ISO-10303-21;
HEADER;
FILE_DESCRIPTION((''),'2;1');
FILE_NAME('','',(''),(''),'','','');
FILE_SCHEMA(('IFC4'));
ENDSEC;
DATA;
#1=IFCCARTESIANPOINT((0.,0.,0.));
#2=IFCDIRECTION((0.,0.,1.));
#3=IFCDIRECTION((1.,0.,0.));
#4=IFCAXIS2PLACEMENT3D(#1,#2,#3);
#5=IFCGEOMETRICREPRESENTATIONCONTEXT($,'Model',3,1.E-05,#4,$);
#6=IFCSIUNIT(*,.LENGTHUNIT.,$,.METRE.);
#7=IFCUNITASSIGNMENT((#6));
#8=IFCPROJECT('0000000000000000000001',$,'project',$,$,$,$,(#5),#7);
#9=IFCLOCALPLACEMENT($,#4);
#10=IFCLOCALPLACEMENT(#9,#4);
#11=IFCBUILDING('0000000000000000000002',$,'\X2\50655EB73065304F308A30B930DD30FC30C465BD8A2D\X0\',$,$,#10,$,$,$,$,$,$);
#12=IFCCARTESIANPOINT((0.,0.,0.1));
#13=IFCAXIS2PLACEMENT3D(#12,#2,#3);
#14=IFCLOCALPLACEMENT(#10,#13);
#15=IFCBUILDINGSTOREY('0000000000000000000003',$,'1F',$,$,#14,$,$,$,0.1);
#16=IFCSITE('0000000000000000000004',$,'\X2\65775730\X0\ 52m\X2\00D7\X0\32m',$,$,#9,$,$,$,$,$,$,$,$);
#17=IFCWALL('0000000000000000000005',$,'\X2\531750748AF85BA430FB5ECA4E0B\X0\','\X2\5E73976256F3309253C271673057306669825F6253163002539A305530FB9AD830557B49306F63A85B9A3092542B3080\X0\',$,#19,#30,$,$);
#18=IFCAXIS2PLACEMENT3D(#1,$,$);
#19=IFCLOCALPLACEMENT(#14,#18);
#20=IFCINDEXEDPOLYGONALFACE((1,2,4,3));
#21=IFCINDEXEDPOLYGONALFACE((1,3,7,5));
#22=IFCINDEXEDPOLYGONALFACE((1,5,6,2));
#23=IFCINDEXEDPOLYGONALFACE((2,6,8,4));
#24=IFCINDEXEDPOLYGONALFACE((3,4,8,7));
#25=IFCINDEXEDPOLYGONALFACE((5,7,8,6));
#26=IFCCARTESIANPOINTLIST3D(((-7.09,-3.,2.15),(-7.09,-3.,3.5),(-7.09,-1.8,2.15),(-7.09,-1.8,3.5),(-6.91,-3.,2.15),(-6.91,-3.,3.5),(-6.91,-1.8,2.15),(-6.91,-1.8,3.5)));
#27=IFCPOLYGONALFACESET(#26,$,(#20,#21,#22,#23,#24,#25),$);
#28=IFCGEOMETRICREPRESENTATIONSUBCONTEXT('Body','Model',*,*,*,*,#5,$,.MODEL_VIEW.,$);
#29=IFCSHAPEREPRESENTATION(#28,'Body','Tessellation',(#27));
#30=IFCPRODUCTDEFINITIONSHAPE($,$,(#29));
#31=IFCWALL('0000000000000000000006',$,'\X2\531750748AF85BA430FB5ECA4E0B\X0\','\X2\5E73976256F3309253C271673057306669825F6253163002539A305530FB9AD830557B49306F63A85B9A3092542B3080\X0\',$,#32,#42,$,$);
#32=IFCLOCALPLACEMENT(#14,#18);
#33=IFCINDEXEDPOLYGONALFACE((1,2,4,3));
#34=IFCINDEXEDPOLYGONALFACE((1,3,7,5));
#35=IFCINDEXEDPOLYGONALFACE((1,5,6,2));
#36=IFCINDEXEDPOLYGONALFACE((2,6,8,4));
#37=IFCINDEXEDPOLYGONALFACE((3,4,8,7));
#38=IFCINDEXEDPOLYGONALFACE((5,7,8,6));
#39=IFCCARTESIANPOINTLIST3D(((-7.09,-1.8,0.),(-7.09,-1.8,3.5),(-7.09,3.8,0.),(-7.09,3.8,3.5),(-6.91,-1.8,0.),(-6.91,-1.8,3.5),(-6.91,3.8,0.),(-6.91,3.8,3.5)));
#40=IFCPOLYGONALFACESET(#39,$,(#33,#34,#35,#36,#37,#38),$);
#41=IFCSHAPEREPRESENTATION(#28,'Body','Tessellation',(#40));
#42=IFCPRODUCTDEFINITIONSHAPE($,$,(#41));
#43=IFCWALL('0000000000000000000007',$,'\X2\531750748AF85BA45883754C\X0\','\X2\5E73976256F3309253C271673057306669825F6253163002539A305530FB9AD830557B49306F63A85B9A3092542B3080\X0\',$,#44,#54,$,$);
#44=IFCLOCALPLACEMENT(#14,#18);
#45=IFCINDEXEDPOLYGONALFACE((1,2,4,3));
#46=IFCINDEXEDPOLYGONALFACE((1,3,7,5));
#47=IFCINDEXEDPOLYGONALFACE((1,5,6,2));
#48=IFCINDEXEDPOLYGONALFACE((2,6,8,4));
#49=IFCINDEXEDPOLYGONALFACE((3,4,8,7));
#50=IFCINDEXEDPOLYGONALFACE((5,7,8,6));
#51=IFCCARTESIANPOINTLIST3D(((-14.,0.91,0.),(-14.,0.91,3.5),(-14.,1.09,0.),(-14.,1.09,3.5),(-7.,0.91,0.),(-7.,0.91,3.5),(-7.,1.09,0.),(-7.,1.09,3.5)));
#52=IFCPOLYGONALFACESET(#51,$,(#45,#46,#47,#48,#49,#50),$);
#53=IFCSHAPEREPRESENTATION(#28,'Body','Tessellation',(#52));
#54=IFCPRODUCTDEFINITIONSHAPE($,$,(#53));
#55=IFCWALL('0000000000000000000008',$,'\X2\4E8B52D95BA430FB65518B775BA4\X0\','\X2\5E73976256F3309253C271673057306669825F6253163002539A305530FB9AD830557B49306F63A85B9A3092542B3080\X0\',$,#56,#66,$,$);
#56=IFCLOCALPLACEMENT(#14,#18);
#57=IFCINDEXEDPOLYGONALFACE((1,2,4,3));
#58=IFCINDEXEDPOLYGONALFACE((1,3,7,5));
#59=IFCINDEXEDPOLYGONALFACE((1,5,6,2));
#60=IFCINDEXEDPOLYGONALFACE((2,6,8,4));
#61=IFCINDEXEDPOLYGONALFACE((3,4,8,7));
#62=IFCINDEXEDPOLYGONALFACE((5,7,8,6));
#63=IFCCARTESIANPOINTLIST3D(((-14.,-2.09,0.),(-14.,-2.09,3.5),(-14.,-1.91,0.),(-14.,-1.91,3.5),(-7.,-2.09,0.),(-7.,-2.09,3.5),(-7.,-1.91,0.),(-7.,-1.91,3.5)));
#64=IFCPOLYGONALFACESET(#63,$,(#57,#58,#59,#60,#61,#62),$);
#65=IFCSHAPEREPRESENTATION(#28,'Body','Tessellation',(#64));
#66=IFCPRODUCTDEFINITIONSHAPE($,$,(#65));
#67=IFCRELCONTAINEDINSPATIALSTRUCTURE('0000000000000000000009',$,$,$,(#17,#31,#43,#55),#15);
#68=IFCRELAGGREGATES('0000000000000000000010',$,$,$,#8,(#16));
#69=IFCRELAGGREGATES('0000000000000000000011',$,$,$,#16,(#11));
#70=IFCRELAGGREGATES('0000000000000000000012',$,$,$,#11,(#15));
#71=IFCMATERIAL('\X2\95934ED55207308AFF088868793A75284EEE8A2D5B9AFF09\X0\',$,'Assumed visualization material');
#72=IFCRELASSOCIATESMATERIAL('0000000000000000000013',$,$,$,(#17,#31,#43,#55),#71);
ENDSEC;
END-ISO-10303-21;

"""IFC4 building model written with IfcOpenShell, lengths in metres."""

from ifc_helpers import new_model, si_unit, frame, origin_with_axes, place, context, subcontext, project, spatial, rectangle, extrude, material, element, save


model = new_model("IFC4")

# Units and contexts
model_context = context("Model", 3, precision=1e-05, world=origin_with_axes())
body_context = subcontext(model_context, "Body", "Model", "MODEL_VIEW")
ifc_project = project(units=[si_unit("LENGTHUNIT", "METRE")], contexts=[model_context])

# Site, building, storey
site_placement = place(None, origin_with_axes())
site = spatial("IfcSite", under=ifc_project, at=site_placement, Name="敷地 52m×32m")
building_placement = place(site_placement, origin_with_axes())
building = spatial("IfcBuilding", under=site, at=building_placement, Name="健康づくりスポーツ施設")
storey_placement = place(building_placement, frame((0.0, 0.0, 0.1), z_axis=(0.0, 0.0, 1.0), x_axis=(1.0, 0.0, 0.0)))
storey = spatial("IfcBuildingStorey", under=building, at=storey_placement, Name="1F", Elevation=0.1)

# Walls
ifc_material_1 = material(Name="間仕切り（表示用仮設定）", Category="Assumed visualization material")
wall_1_placement = place(storey_placement, frame((-7.0, -2.4, 2.15), z_axis=(0.0, 0.0, 1.0), x_axis=(1.0, 0.0, 0.0)))
element("IfcWall", 1, at=wall_1_placement, inside=storey, material=ifc_material_1, Name="北側諸室・廊下", Description="平面図を参照して概形化。厚さ・高さ等は推定を含む", context=body_context, shape_type="SweptSolid", body=[
    extrude(rectangle(XDim=0.18, YDim=1.2), origin_with_axes(), (0.0, 0.0, 1.0), 1.35),
])
wall_2_placement = place(storey_placement, frame((-7.0, 1.0, 0.0), z_axis=(0.0, 0.0, 1.0), x_axis=(1.0, 0.0, 0.0)))
element("IfcWall", 2, at=wall_2_placement, inside=storey, material=ifc_material_1, Name="北側諸室・廊下", Description="平面図を参照して概形化。厚さ・高さ等は推定を含む", context=body_context, shape_type="SweptSolid", body=[
    extrude(rectangle(XDim=0.18, YDim=5.6), origin_with_axes(), (0.0, 0.0, 1.0), 3.5),
])
for number, where, z_axis, x_axis, name in (
    (3, (-10.5, 1.0, 0.0), (0.0, 0.0, 1.0), (1.0, 0.0, 0.0), "北側諸室境界"),
    (4, (-10.5, -2.0, 0.0), (0.0, 0.0, 1.0), (1.0, 0.0, 0.0), "事務室・救護室"),
):
    element("IfcWall", number, at=place(storey_placement, frame(where, z_axis=z_axis, x_axis=x_axis)), inside=storey, material=ifc_material_1, Name=name, Description="平面図を参照して概形化。厚さ・高さ等は推定を含む", context=body_context, shape_type="SweptSolid", body=[
        extrude(rectangle(XDim=7.0, YDim=0.18), origin_with_axes(), (0.0, 0.0, 1.0), 3.5),
    ])

save(model, "model.ifc")
